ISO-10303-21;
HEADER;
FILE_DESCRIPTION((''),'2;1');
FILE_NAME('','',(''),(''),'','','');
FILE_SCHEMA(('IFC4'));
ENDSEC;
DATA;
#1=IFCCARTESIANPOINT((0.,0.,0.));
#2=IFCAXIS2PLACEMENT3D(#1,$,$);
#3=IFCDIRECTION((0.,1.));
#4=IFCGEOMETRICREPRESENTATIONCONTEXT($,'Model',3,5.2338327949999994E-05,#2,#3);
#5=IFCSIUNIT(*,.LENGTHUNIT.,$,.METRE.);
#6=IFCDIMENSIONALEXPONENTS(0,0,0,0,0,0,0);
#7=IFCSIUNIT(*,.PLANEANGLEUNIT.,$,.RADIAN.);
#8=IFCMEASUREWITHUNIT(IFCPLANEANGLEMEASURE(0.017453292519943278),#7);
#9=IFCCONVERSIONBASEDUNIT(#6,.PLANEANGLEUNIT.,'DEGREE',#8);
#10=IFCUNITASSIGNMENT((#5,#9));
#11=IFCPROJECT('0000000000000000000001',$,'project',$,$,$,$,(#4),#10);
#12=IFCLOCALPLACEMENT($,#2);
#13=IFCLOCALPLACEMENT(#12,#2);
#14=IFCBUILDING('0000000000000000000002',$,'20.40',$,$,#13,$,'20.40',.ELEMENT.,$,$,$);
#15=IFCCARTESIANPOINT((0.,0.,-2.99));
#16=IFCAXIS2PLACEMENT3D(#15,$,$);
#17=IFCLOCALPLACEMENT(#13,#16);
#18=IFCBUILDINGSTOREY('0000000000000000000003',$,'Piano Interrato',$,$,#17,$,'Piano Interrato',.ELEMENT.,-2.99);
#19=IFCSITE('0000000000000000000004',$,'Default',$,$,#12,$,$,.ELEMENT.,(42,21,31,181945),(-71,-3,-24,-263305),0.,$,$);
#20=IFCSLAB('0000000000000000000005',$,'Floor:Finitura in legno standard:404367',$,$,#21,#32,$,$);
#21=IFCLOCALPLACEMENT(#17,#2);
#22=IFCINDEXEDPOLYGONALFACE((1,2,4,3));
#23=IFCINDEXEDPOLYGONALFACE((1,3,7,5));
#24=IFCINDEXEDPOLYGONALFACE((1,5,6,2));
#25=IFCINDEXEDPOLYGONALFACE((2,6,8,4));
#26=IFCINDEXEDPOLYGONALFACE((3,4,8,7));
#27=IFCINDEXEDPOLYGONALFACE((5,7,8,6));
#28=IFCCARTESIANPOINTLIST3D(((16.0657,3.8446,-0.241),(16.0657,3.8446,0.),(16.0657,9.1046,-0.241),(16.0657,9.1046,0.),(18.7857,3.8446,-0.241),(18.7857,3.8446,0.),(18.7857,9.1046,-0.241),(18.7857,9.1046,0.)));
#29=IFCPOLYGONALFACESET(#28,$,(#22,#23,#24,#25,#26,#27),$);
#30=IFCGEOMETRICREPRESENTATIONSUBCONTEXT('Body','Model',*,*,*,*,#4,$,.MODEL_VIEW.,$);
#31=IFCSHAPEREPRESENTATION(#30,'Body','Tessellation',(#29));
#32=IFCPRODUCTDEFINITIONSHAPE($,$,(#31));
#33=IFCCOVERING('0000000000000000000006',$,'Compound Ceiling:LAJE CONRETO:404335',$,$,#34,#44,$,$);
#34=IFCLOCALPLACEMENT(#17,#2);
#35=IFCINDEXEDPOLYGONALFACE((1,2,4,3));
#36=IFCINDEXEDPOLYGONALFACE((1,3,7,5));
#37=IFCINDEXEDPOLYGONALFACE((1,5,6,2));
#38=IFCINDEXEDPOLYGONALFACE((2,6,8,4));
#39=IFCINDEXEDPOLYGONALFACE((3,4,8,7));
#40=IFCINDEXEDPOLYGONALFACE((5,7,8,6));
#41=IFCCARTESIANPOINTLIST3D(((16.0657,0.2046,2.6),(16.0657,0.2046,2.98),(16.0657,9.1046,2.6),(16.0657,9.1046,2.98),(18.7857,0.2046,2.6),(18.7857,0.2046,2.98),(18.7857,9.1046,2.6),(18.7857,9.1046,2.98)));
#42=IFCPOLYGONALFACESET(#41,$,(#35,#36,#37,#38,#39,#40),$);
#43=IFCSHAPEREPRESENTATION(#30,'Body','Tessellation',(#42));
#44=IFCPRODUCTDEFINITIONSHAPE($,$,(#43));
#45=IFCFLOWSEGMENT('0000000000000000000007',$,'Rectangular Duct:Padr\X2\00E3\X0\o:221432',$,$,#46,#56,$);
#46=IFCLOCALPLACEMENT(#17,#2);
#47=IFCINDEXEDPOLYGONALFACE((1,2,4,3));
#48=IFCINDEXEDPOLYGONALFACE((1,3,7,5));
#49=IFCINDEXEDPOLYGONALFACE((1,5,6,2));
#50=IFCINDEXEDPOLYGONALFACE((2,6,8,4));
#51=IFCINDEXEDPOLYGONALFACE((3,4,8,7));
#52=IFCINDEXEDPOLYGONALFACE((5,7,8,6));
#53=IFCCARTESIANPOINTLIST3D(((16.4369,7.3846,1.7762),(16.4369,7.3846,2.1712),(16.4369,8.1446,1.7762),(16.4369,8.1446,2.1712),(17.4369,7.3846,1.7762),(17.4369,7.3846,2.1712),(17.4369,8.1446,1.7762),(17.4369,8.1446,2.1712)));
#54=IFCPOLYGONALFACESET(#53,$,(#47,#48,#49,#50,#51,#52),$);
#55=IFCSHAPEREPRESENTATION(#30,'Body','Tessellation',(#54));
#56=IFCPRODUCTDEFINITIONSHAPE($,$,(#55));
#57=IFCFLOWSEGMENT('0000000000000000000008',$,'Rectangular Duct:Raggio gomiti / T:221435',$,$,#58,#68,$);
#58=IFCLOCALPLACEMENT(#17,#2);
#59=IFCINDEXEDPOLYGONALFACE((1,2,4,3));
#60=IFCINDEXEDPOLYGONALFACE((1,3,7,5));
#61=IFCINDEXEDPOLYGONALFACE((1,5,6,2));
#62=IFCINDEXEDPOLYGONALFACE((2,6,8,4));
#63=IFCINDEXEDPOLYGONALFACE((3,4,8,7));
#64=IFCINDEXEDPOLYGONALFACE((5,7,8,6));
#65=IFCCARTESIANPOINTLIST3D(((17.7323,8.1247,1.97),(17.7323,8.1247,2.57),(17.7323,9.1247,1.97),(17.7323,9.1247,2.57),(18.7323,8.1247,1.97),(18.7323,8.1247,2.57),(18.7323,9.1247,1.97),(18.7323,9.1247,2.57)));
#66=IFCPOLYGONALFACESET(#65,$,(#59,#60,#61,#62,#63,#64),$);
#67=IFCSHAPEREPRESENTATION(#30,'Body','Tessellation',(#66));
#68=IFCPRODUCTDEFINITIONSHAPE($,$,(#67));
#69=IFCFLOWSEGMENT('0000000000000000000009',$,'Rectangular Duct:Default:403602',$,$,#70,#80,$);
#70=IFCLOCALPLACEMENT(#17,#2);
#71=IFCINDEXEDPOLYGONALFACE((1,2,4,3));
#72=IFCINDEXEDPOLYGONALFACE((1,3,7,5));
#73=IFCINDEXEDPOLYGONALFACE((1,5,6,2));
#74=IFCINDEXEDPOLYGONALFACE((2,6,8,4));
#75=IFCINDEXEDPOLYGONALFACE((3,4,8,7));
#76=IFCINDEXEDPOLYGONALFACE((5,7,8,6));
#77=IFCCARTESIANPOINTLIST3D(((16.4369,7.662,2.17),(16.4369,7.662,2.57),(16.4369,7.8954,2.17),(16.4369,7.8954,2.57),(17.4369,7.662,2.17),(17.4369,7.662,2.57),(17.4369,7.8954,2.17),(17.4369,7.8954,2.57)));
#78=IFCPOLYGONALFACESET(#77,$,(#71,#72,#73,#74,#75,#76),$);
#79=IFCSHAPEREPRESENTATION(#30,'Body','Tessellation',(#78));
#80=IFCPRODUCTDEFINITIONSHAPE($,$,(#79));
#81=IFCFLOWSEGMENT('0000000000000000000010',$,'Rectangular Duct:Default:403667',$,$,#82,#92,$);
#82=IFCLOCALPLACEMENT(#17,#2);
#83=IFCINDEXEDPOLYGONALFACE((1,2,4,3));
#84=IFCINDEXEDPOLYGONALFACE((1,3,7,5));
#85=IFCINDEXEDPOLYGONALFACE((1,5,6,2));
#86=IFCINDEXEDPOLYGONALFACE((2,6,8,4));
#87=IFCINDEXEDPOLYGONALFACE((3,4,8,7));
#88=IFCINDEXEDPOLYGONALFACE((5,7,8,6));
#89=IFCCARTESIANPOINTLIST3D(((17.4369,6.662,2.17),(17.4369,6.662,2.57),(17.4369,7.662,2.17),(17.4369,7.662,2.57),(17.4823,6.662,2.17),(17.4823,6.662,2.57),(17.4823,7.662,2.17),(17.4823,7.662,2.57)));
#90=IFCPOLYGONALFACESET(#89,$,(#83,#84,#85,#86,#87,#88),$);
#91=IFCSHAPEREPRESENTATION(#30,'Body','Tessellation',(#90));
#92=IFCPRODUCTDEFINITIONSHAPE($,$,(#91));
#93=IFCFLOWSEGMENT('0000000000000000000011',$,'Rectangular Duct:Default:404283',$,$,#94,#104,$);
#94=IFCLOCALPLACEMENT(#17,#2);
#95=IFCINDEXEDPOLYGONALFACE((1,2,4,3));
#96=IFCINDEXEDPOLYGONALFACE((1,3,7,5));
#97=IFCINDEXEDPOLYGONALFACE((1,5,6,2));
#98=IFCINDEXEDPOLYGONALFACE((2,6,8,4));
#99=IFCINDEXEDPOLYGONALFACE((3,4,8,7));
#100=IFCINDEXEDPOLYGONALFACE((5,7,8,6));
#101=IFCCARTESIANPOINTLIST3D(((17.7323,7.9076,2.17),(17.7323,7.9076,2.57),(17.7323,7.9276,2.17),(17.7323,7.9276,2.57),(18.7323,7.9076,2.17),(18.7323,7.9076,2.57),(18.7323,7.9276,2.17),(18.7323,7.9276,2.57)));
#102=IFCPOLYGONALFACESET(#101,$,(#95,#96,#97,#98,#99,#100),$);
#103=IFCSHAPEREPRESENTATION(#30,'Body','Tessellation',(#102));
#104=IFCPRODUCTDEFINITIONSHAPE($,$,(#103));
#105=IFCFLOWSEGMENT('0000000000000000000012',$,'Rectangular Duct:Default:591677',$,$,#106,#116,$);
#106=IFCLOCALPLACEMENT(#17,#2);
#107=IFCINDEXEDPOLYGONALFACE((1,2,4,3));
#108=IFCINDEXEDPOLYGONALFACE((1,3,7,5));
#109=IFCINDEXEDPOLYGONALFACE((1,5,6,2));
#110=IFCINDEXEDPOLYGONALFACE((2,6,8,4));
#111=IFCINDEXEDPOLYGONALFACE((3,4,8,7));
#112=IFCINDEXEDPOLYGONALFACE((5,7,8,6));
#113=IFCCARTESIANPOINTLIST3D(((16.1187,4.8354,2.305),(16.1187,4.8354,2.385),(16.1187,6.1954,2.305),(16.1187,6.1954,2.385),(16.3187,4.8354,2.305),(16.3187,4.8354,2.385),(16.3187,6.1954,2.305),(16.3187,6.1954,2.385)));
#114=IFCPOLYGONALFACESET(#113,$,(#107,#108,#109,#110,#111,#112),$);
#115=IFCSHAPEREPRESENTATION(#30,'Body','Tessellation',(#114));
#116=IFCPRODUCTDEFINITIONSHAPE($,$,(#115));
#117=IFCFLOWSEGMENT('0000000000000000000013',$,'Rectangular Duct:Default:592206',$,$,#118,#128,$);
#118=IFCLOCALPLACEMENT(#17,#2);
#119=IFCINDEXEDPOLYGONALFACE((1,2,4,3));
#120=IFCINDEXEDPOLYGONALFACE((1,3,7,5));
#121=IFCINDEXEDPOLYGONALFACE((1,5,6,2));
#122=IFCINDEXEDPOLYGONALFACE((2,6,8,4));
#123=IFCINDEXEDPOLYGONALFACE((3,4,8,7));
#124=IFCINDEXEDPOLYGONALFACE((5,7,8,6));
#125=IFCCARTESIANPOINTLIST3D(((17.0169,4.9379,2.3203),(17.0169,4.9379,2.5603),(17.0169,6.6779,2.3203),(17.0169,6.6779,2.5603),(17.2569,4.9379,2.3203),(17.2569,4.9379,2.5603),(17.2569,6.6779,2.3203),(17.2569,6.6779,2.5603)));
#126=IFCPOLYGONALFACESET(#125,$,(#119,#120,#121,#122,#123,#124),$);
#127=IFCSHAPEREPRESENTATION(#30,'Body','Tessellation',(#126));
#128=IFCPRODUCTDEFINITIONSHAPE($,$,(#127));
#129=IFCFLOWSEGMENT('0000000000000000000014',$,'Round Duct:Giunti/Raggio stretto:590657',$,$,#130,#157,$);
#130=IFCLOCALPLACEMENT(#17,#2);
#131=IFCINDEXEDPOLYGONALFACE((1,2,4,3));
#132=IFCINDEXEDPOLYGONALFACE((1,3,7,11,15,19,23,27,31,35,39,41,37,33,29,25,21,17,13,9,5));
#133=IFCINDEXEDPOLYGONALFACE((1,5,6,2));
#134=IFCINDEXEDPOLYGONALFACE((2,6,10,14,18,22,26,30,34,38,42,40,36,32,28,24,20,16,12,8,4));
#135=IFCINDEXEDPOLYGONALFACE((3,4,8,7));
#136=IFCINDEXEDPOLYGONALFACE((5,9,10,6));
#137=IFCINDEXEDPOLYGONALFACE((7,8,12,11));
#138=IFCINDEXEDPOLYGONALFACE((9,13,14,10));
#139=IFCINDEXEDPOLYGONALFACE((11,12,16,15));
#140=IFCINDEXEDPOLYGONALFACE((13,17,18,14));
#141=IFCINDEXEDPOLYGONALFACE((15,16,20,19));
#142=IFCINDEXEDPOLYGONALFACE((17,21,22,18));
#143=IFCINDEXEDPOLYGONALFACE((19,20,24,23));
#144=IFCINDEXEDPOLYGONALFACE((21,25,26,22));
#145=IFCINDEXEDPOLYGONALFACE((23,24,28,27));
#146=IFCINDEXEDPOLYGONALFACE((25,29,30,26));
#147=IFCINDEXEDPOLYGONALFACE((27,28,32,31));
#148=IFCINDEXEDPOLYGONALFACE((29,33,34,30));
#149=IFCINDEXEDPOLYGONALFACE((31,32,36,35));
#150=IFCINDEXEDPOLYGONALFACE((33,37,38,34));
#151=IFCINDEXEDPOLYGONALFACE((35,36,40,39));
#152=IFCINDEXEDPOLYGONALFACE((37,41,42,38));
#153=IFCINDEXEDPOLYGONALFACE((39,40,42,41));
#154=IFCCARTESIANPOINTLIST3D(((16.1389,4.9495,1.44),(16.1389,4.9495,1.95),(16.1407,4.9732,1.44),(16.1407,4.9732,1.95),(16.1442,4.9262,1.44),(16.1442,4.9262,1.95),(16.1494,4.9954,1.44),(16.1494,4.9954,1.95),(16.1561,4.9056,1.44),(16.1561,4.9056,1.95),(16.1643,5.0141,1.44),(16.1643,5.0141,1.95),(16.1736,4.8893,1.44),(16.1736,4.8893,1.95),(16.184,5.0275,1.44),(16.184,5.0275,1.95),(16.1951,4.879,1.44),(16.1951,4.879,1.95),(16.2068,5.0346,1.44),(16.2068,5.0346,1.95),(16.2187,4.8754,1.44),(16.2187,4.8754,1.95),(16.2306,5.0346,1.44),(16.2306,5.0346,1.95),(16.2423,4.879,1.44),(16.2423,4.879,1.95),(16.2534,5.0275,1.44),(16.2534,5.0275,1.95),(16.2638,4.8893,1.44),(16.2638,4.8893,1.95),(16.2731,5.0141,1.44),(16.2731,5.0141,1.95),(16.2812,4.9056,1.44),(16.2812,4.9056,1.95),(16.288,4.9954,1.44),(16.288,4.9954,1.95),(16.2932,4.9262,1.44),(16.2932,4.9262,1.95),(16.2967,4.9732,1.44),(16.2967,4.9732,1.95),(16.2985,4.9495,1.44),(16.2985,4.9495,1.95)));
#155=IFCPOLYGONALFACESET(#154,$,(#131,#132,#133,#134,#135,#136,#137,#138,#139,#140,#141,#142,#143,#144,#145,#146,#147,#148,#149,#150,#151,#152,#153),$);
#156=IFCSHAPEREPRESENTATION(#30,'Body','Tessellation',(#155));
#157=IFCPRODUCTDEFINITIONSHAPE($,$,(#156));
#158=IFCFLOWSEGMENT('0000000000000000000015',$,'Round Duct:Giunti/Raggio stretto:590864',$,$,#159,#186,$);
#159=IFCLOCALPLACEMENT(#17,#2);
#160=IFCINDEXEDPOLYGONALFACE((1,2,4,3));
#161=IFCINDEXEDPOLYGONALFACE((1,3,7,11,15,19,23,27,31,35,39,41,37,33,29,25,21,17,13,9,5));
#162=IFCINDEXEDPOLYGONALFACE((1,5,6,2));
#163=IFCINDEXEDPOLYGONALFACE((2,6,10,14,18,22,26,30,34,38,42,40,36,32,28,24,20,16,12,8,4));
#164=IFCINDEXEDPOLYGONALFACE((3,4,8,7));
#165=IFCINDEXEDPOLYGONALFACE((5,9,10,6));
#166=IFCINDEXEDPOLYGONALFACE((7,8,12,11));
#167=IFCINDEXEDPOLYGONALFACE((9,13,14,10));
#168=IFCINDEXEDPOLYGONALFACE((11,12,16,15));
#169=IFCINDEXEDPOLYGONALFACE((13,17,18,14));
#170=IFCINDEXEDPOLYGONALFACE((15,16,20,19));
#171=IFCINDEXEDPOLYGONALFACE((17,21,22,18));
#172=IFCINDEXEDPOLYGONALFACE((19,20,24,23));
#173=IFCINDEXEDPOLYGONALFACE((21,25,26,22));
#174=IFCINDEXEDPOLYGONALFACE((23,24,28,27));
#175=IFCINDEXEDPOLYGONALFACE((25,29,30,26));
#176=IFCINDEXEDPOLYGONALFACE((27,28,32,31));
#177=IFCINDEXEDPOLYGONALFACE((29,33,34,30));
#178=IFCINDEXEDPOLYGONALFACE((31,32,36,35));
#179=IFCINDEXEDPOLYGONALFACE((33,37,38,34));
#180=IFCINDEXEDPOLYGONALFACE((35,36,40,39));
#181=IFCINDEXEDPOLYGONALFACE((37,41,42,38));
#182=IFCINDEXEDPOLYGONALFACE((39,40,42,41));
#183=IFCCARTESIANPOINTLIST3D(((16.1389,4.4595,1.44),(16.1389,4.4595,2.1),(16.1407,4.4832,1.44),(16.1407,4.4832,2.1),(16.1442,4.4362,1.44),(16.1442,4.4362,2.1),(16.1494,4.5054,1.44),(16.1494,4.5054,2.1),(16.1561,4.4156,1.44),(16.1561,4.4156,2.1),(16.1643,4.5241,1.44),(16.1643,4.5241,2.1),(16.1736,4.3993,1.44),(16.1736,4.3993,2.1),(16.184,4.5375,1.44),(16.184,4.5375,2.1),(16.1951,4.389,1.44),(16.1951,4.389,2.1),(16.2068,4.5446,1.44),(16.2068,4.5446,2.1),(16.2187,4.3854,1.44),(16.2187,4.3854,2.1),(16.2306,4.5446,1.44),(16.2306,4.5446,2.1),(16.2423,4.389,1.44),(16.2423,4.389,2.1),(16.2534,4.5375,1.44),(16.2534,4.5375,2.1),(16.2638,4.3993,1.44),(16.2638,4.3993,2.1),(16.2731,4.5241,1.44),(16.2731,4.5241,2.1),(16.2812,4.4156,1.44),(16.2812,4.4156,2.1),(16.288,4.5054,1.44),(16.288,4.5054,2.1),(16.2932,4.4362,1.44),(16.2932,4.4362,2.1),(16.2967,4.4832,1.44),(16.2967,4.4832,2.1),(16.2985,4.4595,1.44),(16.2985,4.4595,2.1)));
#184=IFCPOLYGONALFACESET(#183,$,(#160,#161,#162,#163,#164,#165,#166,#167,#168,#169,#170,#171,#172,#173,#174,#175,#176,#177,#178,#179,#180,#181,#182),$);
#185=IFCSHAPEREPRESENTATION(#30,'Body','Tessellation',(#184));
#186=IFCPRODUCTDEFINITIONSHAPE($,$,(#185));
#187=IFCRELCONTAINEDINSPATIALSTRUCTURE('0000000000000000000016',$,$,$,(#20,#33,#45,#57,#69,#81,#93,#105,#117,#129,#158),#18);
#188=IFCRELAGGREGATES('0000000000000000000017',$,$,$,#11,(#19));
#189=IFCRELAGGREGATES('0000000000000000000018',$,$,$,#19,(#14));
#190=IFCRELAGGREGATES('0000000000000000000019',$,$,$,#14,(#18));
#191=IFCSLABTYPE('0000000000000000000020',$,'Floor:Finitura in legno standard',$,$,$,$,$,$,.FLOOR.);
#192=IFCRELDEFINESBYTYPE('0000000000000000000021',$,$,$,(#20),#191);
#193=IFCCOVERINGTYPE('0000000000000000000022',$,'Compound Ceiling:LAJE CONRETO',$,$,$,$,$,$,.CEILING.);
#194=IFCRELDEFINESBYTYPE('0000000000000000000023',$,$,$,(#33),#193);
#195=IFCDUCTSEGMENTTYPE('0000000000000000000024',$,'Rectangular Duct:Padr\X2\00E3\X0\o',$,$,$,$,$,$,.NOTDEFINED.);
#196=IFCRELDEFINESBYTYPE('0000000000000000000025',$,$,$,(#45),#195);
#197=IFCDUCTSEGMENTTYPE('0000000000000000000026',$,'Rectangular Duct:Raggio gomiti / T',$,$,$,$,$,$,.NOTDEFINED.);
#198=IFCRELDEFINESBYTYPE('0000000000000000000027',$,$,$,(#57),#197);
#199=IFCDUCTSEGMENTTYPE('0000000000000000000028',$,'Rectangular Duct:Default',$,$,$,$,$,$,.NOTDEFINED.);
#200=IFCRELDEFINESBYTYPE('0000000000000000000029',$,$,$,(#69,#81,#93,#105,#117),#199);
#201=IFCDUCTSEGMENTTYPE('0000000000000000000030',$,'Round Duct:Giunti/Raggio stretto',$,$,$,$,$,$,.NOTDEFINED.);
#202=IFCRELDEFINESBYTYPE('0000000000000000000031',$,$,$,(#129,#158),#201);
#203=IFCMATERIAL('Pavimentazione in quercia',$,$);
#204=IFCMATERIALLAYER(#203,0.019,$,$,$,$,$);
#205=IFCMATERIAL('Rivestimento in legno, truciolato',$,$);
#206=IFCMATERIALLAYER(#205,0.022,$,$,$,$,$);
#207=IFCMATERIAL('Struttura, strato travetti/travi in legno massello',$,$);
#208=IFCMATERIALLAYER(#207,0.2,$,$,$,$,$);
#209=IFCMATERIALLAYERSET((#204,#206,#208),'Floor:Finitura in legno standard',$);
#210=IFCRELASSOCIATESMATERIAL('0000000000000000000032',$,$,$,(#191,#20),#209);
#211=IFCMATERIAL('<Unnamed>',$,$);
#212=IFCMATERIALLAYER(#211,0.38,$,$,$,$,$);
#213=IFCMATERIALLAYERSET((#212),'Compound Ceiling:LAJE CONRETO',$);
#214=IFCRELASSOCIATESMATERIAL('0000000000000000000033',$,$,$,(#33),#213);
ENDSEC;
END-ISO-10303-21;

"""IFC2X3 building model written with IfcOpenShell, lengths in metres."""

from ifc_helpers import new_model, entity, si_unit, converted_unit, direction, frame, frame_2d, origin, origin_2d_with_axis, place, context, subcontext, project, spatial, rectangle, circle, extrude, material, layer, layer_set, layer_usage, type_object, element, save


model = new_model("IFC2X3")

# Units and contexts
model_context = context("Model", 3, precision=5.2338327949999994e-05, world=origin(), true_north=direction((0.0, 1.0)))
body_context = subcontext(model_context, "Body", "Model", "MODEL_VIEW")
ifc_project = project(units=[si_unit("LENGTHUNIT", "METRE"), converted_unit("PLANEANGLEUNIT", "DEGREE", entity("IfcPlaneAngleMeasure", 0.017453292519943278), si_unit("PLANEANGLEUNIT", "RADIAN"), dimensions=[0, 0, 0, 0, 0, 0, 0])], contexts=[model_context])

# Site, building, storey
site_placement = place(None, origin())
site = spatial("IfcSite", under=ifc_project, at=site_placement, Name="Default", CompositionType="ELEMENT", RefLatitude=(42, 21, 31, 181945), RefLongitude=(-71, -3, -24, -263305), RefElevation=0.0)
building_placement = place(site_placement, origin())
building = spatial("IfcBuilding", under=site, at=building_placement, Name="20.40", LongName="20.40", CompositionType="ELEMENT")
storey_placement = place(building_placement, frame((0.0, 0.0, -2.99)))
storey = spatial("IfcBuildingStorey", under=building, at=storey_placement, Name="Piano Interrato", LongName="Piano Interrato", CompositionType="ELEMENT", Elevation=-2.99)

# Slab
ifc_material_1 = material(Name="Pavimentazione in quercia")
ifc_layer_1 = layer(ifc_material_1, 0.019)
ifc_material_2 = material(Name="Rivestimento in legno, truciolato")
ifc_layer_2 = layer(ifc_material_2, 0.022)
ifc_material_3 = material(Name="Struttura, strato travetti/travi in legno massello")
ifc_layer_3 = layer(ifc_material_3, 0.2)
ifc_layer_set_1 = layer_set([ifc_layer_1, ifc_layer_2, ifc_layer_3], Name="Floor:Finitura in legno standard")
ifc_layer_usage_1 = layer_usage(ifc_layer_set_1, "AXIS3", "POSITIVE", 0.0)
slab_type = type_object("IfcSlabType", Name="Floor:Finitura in legno standard", PredefinedType="FLOOR", material=ifc_layer_set_1)
slab_placement = place(storey_placement, origin())
element("IfcSlab", 1, at=slab_placement, inside=storey, type_object=slab_type, material=ifc_layer_usage_1, Name="Floor:Finitura in legno standard:404367", context=body_context, shape_type="SweptSolid", body=[
    extrude(rectangle(XDim=5.26, YDim=2.72, at=frame_2d((0.0, 0.0), x_axis=(1.0, 0.0))), frame((17.4257, 6.4746, 0.0), z_axis=(0.0, 0.0, -1.0), x_axis=(0.0, 1.0, 0.0)), (0.0, 0.0, 1.0), 0.241),
])

# Covering
ifc_material_4 = material(Name="<Unnamed>")
ifc_layer_4 = layer(ifc_material_4, 0.38)
ifc_layer_set_2 = layer_set([ifc_layer_4], Name="Compound Ceiling:LAJE CONRETO")
ifc_layer_usage_2 = layer_usage(ifc_layer_set_2, "AXIS3", "NEGATIVE", 0.38)
covering_type = type_object("IfcCoveringType", Name="Compound Ceiling:LAJE CONRETO", PredefinedType="CEILING")
covering_placement = place(storey_placement, origin())
element("IfcCovering", 2, at=covering_placement, inside=storey, type_object=covering_type, material=ifc_layer_usage_2, Name="Compound Ceiling:LAJE CONRETO:404335", context=body_context, shape_type="SweptSolid", body=[
    extrude(rectangle(XDim=2.72, YDim=8.9, at=frame_2d((0.0, 0.0), x_axis=(1.0, 0.0))), frame((17.4257, 4.6546, 2.6), z_axis=(0.0, 0.0, 1.0), x_axis=(-1.0, 0.0, 0.0)), (0.0, 0.0, 1.0), 0.38),
])

# Flow segments
duct_segment_type_1 = type_object("IfcDuctSegmentType", Name="Rectangular Duct:Padrão", PredefinedType="NOTDEFINED")
flow_segment_1_placement = place(storey_placement, origin())
element("IfcFlowSegment", 3, at=flow_segment_1_placement, inside=storey, type_object=duct_segment_type_1, Name="Rectangular Duct:Padrão:221432", context=body_context, shape_type="SweptSolid", body=[
    extrude(rectangle(XDim=0.76, YDim=1.0, at=origin_2d_with_axis()), frame((16.9369, 7.7646, 1.7762), z_axis=(0.0, 0.0, 1.0), x_axis=(0.0, 1.0, 0.0)), (0.0, 0.0, 1.0), 0.395),
])
duct_segment_type_2 = type_object("IfcDuctSegmentType", Name="Rectangular Duct:Raggio gomiti / T", PredefinedType="NOTDEFINED")
flow_segment_2_placement = place(storey_placement, origin())
element("IfcFlowSegment", 4, at=flow_segment_2_placement, inside=storey, type_object=duct_segment_type_2, Name="Rectangular Duct:Raggio gomiti / T:221435", context=body_context, shape_type="SweptSolid", body=[
    extrude(rectangle(XDim=1.0, YDim=1.0, at=frame_2d((0.0, 0.0), x_axis=(1.0, 0.0))), frame((18.2323, 8.6247, 1.97), z_axis=(0.0, 0.0, 1.0), x_axis=(0.0, 1.0, 0.0)), (0.0, 0.0, 1.0), 0.6),
])
duct_segment_type_3 = type_object("IfcDuctSegmentType", Name="Rectangular Duct:Default", PredefinedType="NOTDEFINED")
flow_segment_3_placement = place(storey_placement, origin())
element("IfcFlowSegment", 5, at=flow_segment_3_placement, inside=storey, type_object=duct_segment_type_3, Name="Rectangular Duct:Default:403602", context=body_context, shape_type="SweptSolid", body=[
    extrude(rectangle(XDim=0.2334, YDim=1.0, at=frame_2d((0.0, 0.0), x_axis=(1.0, 0.0))), frame((16.9369, 7.7787, 2.17), z_axis=(0.0, 0.0, 1.0), x_axis=(0.0, -1.0, 0.0)), (0.0, 0.0, 1.0), 0.4),
])
flow_segment_4_placement = place(storey_placement, origin())
element("IfcFlowSegment", 6, at=flow_segment_4_placement, inside=storey, type_object=duct_segment_type_3, Name="Rectangular Duct:Default:403667", context=body_context, shape_type="SweptSolid", body=[
    extrude(rectangle(XDim=0.0454, YDim=1.0, at=frame_2d((0.0, 0.0), x_axis=(1.0, 0.0))), frame((17.4596, 7.162, 2.17), z_axis=(0.0, 0.0, 1.0), x_axis=(-1.0, 0.0, 0.0)), (0.0, 0.0, 1.0), 0.4),
])
flow_segment_5_placement = place(storey_placement, origin())
element("IfcFlowSegment", 7, at=flow_segment_5_placement, inside=storey, type_object=duct_segment_type_3, Name="Rectangular Duct:Default:404283", context=body_context, shape_type="SweptSolid", body=[
    extrude(rectangle(XDim=0.02, YDim=1.0, at=frame_2d((0.0, 0.0), x_axis=(1.0, 0.0))), frame((18.2323, 7.9176, 2.17), z_axis=(0.0, 0.0, 1.0), x_axis=(0.0, -1.0, 0.0)), (0.0, 0.0, 1.0), 0.4),
])
flow_segment_6_placement = place(storey_placement, origin())
element("IfcFlowSegment", 8, at=flow_segment_6_placement, inside=storey, type_object=duct_segment_type_3, Name="Rectangular Duct:Default:591677", context=body_context, shape_type="SweptSolid", body=[
    extrude(rectangle(XDim=1.36, YDim=0.2, at=frame_2d((0.0, 0.0), x_axis=(1.0, 0.0))), frame((16.2187, 5.5154, 2.305), z_axis=(0.0, 0.0, 1.0), x_axis=(0.0, 1.0, 0.0)), (0.0, 0.0, 1.0), 0.08),
])
flow_segment_7_placement = place(storey_placement, origin())
element("IfcFlowSegment", 9, at=flow_segment_7_placement, inside=storey, type_object=duct_segment_type_3, Name="Rectangular Duct:Default:592206", context=body_context, shape_type="SweptSolid", body=[
    extrude(rectangle(XDim=1.74, YDim=0.24, at=frame_2d((0.0, 0.0), x_axis=(1.0, 0.0))), frame((17.1369, 5.8079, 2.3203), z_axis=(0.0, 0.0, 1.0), x_axis=(0.0, -1.0, 0.0)), (0.0, 0.0, 1.0), 0.24),
])
duct_segment_type_4 = type_object("IfcDuctSegmentType", Name="Round Duct:Giunti/Raggio stretto", PredefinedType="NOTDEFINED")
flow_segment_8_placement = place(storey_placement, origin())
element("IfcFlowSegment", 10, at=flow_segment_8_placement, inside=storey, type_object=duct_segment_type_4, Name="Round Duct:Giunti/Raggio stretto:590657", context=body_context, shape_type="SweptSolid", body=[
    extrude(circle(Radius=0.08, at=origin_2d_with_axis()), frame((16.2187, 4.9554, 1.44), z_axis=(0.0, 0.0, 1.0), x_axis=(0.0, -1.0, 0.0)), (0.0, 0.0, 1.0), 0.51),
])
flow_segment_9_placement = place(storey_placement, origin())
element("IfcFlowSegment", 11, at=flow_segment_9_placement, inside=storey, type_object=duct_segment_type_4, Name="Round Duct:Giunti/Raggio stretto:590864", context=body_context, shape_type="SweptSolid", body=[
    extrude(circle(Radius=0.08, at=origin_2d_with_axis()), frame((16.2187, 4.4654, 1.44), z_axis=(0.0, 0.0, 1.0), x_axis=(0.0, -1.0, 0.0)), (0.0, 0.0, 1.0), 0.66),
])

save(model, "model.ifc")
